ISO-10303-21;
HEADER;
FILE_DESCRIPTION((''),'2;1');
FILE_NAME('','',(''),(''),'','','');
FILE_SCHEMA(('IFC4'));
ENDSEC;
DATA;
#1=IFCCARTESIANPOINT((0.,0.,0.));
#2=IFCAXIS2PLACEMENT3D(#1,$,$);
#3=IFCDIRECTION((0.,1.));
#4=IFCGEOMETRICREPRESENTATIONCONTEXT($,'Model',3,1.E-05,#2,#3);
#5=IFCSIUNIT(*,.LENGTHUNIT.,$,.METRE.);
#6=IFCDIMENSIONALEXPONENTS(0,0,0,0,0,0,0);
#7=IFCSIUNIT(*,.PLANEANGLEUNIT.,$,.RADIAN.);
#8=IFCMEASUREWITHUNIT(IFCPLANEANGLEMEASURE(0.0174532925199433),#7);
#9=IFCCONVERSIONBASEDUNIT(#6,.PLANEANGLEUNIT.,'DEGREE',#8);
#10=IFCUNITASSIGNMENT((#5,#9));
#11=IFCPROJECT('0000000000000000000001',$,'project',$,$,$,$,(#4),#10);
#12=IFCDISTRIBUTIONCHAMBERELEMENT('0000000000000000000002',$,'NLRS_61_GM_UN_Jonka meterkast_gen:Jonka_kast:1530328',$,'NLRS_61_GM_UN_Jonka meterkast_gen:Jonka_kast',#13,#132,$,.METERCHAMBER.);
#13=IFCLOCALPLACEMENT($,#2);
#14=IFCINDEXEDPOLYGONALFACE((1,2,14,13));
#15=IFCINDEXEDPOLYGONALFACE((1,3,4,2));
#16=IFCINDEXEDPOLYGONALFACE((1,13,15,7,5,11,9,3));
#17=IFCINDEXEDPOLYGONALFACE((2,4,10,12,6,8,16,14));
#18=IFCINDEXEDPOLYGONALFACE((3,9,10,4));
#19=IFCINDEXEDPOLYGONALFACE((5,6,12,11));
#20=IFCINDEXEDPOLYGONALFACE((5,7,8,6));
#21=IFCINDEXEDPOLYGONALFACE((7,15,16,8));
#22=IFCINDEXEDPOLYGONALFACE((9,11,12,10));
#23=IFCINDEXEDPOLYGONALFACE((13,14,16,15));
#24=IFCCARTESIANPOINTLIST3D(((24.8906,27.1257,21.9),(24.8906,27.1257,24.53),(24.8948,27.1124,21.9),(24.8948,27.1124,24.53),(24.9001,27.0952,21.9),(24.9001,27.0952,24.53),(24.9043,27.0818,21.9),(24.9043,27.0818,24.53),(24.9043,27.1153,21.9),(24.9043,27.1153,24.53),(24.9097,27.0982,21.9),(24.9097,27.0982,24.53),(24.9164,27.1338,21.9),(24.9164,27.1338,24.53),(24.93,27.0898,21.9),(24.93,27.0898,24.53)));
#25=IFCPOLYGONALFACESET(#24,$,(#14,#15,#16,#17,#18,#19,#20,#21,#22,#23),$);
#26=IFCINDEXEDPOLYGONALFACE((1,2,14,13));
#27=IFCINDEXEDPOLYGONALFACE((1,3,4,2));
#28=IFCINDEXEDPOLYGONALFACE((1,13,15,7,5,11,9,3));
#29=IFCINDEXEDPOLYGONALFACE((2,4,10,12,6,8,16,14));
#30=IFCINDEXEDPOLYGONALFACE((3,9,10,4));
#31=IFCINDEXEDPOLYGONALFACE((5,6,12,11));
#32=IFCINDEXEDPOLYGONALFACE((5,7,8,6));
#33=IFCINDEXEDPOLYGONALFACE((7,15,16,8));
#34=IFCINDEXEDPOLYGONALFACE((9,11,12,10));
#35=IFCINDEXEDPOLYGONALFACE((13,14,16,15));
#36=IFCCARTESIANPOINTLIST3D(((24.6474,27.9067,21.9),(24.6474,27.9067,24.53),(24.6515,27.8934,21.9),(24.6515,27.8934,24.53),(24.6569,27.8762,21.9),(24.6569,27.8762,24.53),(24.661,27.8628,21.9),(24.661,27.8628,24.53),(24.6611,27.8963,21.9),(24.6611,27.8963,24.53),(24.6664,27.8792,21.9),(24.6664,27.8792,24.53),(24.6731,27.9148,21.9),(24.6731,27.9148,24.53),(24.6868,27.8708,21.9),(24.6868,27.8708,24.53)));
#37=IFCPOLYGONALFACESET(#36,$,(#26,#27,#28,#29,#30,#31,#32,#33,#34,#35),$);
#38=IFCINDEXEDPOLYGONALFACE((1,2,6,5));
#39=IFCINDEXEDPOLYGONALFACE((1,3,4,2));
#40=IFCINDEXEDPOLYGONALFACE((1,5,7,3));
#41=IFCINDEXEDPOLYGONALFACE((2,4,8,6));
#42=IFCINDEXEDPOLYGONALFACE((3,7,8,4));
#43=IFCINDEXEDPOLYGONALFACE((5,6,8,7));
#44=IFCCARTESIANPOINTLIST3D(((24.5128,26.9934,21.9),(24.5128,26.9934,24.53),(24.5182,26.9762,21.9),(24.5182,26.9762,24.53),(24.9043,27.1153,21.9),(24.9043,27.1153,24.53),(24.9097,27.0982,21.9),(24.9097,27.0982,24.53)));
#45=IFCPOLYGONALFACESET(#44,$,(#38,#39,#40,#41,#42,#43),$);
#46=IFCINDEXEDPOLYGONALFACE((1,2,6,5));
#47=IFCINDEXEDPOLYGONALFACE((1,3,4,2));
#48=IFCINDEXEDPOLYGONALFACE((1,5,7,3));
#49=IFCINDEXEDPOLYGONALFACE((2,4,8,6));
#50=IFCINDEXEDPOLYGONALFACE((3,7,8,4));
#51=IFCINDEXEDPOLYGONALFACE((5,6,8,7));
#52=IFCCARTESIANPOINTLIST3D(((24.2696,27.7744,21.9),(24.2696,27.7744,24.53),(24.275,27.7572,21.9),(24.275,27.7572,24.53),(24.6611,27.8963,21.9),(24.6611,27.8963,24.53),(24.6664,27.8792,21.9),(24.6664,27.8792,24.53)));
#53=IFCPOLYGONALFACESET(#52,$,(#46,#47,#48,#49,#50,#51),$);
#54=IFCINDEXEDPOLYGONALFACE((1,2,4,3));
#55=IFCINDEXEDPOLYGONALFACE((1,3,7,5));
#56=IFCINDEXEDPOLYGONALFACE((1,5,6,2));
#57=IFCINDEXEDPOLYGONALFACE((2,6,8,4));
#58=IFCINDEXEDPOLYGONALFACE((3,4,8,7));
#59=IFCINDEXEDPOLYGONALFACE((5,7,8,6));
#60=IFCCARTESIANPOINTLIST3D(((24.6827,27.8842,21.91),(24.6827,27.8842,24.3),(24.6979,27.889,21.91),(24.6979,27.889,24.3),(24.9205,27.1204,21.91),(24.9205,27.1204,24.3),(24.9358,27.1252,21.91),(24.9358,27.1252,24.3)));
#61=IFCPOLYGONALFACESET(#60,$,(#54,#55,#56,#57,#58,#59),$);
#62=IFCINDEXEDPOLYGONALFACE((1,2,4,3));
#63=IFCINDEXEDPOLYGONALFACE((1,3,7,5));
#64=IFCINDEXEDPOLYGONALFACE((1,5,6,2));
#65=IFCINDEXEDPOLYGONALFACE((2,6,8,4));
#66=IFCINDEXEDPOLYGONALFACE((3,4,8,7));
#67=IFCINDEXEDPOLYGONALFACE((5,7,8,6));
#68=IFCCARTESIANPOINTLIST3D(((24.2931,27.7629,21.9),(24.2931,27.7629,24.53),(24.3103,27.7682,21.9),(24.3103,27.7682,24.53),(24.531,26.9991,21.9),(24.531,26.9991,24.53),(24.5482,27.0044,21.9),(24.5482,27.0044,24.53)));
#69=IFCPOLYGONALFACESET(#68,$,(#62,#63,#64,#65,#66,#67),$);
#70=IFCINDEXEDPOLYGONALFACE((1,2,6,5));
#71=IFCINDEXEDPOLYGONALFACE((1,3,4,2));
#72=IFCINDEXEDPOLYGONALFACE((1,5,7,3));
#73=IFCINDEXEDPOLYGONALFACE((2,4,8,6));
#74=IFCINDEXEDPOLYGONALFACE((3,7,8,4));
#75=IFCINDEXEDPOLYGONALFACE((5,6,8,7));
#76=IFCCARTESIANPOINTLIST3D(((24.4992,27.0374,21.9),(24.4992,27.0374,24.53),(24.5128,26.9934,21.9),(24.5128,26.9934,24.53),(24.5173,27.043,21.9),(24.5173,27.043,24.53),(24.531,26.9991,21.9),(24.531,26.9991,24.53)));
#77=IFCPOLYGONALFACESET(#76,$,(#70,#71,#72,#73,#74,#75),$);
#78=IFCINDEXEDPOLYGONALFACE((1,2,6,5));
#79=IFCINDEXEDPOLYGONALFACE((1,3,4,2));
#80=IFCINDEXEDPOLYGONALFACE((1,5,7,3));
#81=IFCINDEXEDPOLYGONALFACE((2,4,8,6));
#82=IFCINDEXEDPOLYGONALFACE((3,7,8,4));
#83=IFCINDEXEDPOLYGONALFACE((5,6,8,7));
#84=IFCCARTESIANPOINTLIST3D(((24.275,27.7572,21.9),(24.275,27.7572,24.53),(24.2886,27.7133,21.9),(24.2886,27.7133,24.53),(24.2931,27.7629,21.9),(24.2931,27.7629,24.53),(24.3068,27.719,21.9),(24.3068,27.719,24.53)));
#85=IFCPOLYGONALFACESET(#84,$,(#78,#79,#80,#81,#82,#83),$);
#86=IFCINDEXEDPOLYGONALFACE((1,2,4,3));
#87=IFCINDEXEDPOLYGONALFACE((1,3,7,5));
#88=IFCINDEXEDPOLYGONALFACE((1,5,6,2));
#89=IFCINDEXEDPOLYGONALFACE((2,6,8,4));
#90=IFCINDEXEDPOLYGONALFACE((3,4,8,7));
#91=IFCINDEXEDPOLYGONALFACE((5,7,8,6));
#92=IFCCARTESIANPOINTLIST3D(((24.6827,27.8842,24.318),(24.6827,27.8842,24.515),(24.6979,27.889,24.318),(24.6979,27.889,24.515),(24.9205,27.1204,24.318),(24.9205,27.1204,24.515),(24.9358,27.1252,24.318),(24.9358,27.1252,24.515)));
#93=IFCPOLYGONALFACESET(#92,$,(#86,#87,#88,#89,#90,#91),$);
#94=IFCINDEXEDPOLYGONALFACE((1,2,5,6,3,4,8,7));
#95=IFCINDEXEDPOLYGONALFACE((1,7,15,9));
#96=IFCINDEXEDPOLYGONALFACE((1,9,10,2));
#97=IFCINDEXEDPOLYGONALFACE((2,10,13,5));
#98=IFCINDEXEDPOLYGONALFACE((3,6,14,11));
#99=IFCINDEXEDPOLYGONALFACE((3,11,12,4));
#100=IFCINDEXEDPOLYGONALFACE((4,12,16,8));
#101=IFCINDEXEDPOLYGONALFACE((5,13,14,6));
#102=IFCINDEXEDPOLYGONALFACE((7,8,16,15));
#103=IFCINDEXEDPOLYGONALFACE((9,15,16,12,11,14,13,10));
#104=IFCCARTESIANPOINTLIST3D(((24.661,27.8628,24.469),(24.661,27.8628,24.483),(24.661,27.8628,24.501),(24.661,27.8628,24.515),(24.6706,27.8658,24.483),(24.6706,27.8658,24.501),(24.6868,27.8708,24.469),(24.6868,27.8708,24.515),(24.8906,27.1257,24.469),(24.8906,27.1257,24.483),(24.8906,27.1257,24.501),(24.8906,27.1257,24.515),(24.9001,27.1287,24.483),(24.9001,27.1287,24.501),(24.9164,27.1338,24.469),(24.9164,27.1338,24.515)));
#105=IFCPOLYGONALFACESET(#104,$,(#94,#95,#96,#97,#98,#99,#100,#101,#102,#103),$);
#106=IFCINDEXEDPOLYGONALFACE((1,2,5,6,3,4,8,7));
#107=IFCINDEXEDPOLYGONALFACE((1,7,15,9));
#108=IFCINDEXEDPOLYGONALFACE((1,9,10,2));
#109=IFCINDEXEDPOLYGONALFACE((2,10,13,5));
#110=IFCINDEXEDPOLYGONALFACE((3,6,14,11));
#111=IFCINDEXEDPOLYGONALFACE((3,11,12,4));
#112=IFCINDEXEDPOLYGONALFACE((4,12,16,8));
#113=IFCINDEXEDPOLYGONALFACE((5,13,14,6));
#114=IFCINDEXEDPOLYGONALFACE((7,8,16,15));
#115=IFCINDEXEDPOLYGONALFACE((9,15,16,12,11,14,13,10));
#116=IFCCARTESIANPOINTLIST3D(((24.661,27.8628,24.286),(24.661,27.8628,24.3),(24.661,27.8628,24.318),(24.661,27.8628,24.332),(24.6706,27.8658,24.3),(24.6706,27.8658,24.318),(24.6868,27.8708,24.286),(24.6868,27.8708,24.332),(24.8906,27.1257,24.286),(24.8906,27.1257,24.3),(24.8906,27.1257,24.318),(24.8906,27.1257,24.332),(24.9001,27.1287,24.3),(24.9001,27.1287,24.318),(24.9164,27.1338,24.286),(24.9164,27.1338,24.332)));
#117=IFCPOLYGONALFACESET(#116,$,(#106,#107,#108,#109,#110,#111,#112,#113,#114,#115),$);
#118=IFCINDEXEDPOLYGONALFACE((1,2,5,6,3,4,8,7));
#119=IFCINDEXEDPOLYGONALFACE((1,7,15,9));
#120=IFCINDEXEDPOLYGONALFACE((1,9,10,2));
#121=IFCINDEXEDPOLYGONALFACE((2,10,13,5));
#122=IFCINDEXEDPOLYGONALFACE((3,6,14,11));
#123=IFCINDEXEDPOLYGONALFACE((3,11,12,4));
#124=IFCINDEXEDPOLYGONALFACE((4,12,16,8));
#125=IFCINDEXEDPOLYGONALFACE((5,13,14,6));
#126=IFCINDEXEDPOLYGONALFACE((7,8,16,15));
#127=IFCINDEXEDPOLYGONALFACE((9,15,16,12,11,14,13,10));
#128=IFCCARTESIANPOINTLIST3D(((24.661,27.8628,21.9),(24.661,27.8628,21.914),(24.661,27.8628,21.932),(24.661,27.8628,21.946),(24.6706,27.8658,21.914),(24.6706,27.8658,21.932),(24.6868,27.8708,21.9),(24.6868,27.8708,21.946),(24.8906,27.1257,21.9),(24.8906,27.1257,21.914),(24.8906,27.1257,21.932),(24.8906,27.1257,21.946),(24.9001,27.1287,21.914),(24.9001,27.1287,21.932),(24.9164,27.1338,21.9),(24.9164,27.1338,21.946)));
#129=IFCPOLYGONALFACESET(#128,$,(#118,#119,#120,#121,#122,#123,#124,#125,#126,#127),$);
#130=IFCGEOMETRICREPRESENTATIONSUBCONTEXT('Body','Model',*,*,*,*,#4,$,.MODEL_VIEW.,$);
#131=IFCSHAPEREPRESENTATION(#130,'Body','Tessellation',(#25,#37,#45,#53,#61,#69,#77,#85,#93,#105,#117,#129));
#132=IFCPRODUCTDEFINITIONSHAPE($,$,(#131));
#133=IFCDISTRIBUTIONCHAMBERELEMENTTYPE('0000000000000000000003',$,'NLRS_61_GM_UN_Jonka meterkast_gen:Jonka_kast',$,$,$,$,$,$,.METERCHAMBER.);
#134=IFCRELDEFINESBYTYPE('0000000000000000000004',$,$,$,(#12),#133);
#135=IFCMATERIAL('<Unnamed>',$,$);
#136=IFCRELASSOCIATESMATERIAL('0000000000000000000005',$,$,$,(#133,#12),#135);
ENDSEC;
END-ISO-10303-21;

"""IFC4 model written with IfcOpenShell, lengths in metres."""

from ifc_helpers import new_model, entity, si_unit, converted_unit, direction, frame, origin, place, context, subcontext, project, indexed_curve, outline, extrude, source, transform, mapped, material, type_object, type_shapes, element, save


model = new_model("IFC4")

# Units and contexts
model_context = context("Model", 3, precision=1e-05, world=origin(), true_north=direction((0.0, 1.0)))
body_context = subcontext(model_context, "Body", "Model", "MODEL_VIEW")
ifc_project = project(units=[si_unit("LENGTHUNIT", "METRE"), converted_unit("PLANEANGLEUNIT", "DEGREE", entity("IfcPlaneAngleMeasure", 0.0174532925199433), si_unit("PLANEANGLEUNIT", "RADIAN"), dimensions=[0, 0, 0, 0, 0, 0, 0])], contexts=[model_context])

# Distribution chamber element
ifc_material = material(Name="<Unnamed>")
distribution_chamber_element_type = type_object("IfcDistributionChamberElementType", Name="NLRS_61_GM_UN_Jonka meterkast_gen:Jonka_kast", PredefinedType="METERCHAMBER", material=ifc_material)
shared_shape_1 = source(origin(), body_context, "Body", "SweptSolid", [
    extrude(outline(indexed_curve([(-0.0093, -0.023), (0.0178, -0.023), (0.0178, 0.023), (-0.0093, 0.023), (-0.0093, 0.009), (0.0007, 0.009), (0.0007, -0.009), (-0.0093, -0.009), (-0.0093, -0.023)], self_intersect=False)), frame((-0.409, -0.4092, 0.0), z_axis=(0.0, 0.0, 1.0), x_axis=(0.0, -1.0, 0.0)), (0.0, 0.0, 1.0), 2.63),
    extrude(outline(indexed_curve([(-0.0093, -0.023), (0.0178, -0.023), (0.0178, 0.023), (-0.0093, 0.023), (-0.0093, 0.009), (0.0007, 0.009), (0.0007, -0.009), (-0.0093, -0.009), (-0.0093, -0.023)], self_intersect=False)), frame((0.409, -0.4092, 0.0), z_axis=(0.0, 0.0, 1.0), x_axis=(0.0, -1.0, 0.0)), (0.0, 0.0, 1.0), 2.63),
    extrude(outline(indexed_curve([(-0.205, -0.009), (0.205, -0.009), (0.205, 0.009), (-0.205, 0.009), (-0.205, -0.009)], self_intersect=False)), frame((-0.409, -0.205, 0.0), z_axis=(0.0, 0.0, 1.0), x_axis=(0.0, -1.0, 0.0)), (0.0, 0.0, 1.0), 2.63),
    extrude(outline(indexed_curve([(-0.205, -0.009), (0.205, -0.009), (0.205, 0.009), (-0.205, 0.009), (-0.205, -0.009)], self_intersect=False)), frame((0.409, -0.205, 0.0), z_axis=(0.0, 0.0, 1.0), x_axis=(0.0, -1.0, 0.0)), (0.0, 0.0, 1.0), 2.63),
    extrude(outline(indexed_curve([(-0.4, -0.008), (0.4, -0.008), (0.4, 0.008), (-0.4, 0.008), (-0.4, -0.008)], self_intersect=False)), frame((0.0, -0.435, 0.01), z_axis=(0.0, 0.0, 1.0), x_axis=(-1.0, 0.0, 0.0)), (0.0, 0.0, 1.0), 2.39),
    extrude(outline(indexed_curve([(-0.4, -0.009), (0.4, -0.009), (0.4, 0.009), (-0.4, 0.009), (-0.4, -0.009)], self_intersect=False)), frame((0.0, -0.028, 0.0), z_axis=(0.0, 0.0, 1.0), x_axis=(-1.0, 0.0, 0.0)), (0.0, 0.0, 1.0), 2.63),
    extrude(outline(indexed_curve([(-0.023, -0.0095), (0.023, -0.0095), (0.023, 0.0095), (-0.023, 0.0095), (-0.023, -0.0095)], self_intersect=False)), frame((-0.377, -0.0095, 0.0), z_axis=(0.0, 0.0, 1.0), x_axis=(-1.0, 0.0, 0.0)), (0.0, 0.0, 1.0), 2.63),
    extrude(outline(indexed_curve([(-0.023, -0.0095), (0.023, -0.0095), (0.023, 0.0095), (-0.023, 0.0095), (-0.023, -0.0095)], self_intersect=False)), frame((0.377, -0.0095, 0.0), z_axis=(0.0, 0.0, 1.0), x_axis=(-1.0, 0.0, 0.0)), (0.0, 0.0, 1.0), 2.63),
    extrude(outline(indexed_curve([(-0.4, -0.008), (0.4, -0.008), (0.4, 0.008), (-0.4, 0.008), (-0.4, -0.008)], self_intersect=False)), frame((0.0, -0.435, 2.418), z_axis=(0.0, 0.0, 1.0), x_axis=(-1.0, 0.0, 0.0)), (0.0, 0.0, 1.0), 0.197),
    extrude(outline(indexed_curve([(-0.023, -0.0178), (0.023, -0.0178), (0.023, 0.0093), (0.009, 0.0093), (0.009, -0.0007), (-0.009, -0.0007), (-0.009, 0.0093), (-0.023, 0.0093), (-0.023, -0.0178)], self_intersect=False)), frame((-0.386, -0.4092, 2.592), z_axis=(1.0, 0.0, 0.0), x_axis=(0.0, 0.0, -1.0)), (0.0, 0.0, 1.0), 0.772),
    extrude(outline(indexed_curve([(-0.023, -0.0178), (0.023, -0.0178), (0.023, 0.0093), (0.009, 0.0093), (0.009, -0.0007), (-0.009, -0.0007), (-0.009, 0.0093), (-0.023, 0.0093), (-0.023, -0.0178)], self_intersect=False)), frame((-0.386, -0.4092, 2.409), z_axis=(1.0, 0.0, 0.0), x_axis=(0.0, 0.0, -1.0)), (0.0, 0.0, 1.0), 0.772),
    extrude(outline(indexed_curve([(-0.023, -0.0178), (0.023, -0.0178), (0.023, 0.0093), (0.009, 0.0093), (0.009, -0.0007), (-0.009, -0.0007), (-0.009, 0.0093), (-0.023, 0.0093), (-0.023, -0.0178)], self_intersect=False)), frame((-0.386, -0.4092, 0.023), z_axis=(1.0, 0.0, 0.0), x_axis=(0.0, 0.0, -1.0)), (0.0, 0.0, 1.0), 0.772),
])
type_shapes(distribution_chamber_element_type, [shared_shape_1])
placement_1 = place(None, frame((13.1348, 11.9886, 0.0), z_axis=(0.0, 0.0, 1.0), x_axis=(0.954771, 0.297342, 0.0)))
placement_2 = place(placement_1, origin())
placement_3 = place(placement_2, frame((0.0, 0.0, 21.9)))
placement_4 = place(placement_3, origin())
distribution_chamber_element_1_placement = place(placement_4, frame((15.325, 11.343, 0.0), z_axis=(0.0, 0.0, 1.0), x_axis=(0.0, 1.0, 0.0)))
element("IfcDistributionChamberElement", 1, at=distribution_chamber_element_1_placement, type_object=distribution_chamber_element_type, material=ifc_material, Name="NLRS_61_GM_UN_Jonka meterkast_gen:Jonka_kast:1530328", ObjectType="NLRS_61_GM_UN_Jonka meterkast_gen:Jonka_kast", PredefinedType="METERCHAMBER", context=body_context, shape_type="MappedRepresentation", body=[
    mapped(shared_shape_1, transform((0.0, 0.0, 0.0), scale=1.0)),
])

save(model, "model.ifc")
